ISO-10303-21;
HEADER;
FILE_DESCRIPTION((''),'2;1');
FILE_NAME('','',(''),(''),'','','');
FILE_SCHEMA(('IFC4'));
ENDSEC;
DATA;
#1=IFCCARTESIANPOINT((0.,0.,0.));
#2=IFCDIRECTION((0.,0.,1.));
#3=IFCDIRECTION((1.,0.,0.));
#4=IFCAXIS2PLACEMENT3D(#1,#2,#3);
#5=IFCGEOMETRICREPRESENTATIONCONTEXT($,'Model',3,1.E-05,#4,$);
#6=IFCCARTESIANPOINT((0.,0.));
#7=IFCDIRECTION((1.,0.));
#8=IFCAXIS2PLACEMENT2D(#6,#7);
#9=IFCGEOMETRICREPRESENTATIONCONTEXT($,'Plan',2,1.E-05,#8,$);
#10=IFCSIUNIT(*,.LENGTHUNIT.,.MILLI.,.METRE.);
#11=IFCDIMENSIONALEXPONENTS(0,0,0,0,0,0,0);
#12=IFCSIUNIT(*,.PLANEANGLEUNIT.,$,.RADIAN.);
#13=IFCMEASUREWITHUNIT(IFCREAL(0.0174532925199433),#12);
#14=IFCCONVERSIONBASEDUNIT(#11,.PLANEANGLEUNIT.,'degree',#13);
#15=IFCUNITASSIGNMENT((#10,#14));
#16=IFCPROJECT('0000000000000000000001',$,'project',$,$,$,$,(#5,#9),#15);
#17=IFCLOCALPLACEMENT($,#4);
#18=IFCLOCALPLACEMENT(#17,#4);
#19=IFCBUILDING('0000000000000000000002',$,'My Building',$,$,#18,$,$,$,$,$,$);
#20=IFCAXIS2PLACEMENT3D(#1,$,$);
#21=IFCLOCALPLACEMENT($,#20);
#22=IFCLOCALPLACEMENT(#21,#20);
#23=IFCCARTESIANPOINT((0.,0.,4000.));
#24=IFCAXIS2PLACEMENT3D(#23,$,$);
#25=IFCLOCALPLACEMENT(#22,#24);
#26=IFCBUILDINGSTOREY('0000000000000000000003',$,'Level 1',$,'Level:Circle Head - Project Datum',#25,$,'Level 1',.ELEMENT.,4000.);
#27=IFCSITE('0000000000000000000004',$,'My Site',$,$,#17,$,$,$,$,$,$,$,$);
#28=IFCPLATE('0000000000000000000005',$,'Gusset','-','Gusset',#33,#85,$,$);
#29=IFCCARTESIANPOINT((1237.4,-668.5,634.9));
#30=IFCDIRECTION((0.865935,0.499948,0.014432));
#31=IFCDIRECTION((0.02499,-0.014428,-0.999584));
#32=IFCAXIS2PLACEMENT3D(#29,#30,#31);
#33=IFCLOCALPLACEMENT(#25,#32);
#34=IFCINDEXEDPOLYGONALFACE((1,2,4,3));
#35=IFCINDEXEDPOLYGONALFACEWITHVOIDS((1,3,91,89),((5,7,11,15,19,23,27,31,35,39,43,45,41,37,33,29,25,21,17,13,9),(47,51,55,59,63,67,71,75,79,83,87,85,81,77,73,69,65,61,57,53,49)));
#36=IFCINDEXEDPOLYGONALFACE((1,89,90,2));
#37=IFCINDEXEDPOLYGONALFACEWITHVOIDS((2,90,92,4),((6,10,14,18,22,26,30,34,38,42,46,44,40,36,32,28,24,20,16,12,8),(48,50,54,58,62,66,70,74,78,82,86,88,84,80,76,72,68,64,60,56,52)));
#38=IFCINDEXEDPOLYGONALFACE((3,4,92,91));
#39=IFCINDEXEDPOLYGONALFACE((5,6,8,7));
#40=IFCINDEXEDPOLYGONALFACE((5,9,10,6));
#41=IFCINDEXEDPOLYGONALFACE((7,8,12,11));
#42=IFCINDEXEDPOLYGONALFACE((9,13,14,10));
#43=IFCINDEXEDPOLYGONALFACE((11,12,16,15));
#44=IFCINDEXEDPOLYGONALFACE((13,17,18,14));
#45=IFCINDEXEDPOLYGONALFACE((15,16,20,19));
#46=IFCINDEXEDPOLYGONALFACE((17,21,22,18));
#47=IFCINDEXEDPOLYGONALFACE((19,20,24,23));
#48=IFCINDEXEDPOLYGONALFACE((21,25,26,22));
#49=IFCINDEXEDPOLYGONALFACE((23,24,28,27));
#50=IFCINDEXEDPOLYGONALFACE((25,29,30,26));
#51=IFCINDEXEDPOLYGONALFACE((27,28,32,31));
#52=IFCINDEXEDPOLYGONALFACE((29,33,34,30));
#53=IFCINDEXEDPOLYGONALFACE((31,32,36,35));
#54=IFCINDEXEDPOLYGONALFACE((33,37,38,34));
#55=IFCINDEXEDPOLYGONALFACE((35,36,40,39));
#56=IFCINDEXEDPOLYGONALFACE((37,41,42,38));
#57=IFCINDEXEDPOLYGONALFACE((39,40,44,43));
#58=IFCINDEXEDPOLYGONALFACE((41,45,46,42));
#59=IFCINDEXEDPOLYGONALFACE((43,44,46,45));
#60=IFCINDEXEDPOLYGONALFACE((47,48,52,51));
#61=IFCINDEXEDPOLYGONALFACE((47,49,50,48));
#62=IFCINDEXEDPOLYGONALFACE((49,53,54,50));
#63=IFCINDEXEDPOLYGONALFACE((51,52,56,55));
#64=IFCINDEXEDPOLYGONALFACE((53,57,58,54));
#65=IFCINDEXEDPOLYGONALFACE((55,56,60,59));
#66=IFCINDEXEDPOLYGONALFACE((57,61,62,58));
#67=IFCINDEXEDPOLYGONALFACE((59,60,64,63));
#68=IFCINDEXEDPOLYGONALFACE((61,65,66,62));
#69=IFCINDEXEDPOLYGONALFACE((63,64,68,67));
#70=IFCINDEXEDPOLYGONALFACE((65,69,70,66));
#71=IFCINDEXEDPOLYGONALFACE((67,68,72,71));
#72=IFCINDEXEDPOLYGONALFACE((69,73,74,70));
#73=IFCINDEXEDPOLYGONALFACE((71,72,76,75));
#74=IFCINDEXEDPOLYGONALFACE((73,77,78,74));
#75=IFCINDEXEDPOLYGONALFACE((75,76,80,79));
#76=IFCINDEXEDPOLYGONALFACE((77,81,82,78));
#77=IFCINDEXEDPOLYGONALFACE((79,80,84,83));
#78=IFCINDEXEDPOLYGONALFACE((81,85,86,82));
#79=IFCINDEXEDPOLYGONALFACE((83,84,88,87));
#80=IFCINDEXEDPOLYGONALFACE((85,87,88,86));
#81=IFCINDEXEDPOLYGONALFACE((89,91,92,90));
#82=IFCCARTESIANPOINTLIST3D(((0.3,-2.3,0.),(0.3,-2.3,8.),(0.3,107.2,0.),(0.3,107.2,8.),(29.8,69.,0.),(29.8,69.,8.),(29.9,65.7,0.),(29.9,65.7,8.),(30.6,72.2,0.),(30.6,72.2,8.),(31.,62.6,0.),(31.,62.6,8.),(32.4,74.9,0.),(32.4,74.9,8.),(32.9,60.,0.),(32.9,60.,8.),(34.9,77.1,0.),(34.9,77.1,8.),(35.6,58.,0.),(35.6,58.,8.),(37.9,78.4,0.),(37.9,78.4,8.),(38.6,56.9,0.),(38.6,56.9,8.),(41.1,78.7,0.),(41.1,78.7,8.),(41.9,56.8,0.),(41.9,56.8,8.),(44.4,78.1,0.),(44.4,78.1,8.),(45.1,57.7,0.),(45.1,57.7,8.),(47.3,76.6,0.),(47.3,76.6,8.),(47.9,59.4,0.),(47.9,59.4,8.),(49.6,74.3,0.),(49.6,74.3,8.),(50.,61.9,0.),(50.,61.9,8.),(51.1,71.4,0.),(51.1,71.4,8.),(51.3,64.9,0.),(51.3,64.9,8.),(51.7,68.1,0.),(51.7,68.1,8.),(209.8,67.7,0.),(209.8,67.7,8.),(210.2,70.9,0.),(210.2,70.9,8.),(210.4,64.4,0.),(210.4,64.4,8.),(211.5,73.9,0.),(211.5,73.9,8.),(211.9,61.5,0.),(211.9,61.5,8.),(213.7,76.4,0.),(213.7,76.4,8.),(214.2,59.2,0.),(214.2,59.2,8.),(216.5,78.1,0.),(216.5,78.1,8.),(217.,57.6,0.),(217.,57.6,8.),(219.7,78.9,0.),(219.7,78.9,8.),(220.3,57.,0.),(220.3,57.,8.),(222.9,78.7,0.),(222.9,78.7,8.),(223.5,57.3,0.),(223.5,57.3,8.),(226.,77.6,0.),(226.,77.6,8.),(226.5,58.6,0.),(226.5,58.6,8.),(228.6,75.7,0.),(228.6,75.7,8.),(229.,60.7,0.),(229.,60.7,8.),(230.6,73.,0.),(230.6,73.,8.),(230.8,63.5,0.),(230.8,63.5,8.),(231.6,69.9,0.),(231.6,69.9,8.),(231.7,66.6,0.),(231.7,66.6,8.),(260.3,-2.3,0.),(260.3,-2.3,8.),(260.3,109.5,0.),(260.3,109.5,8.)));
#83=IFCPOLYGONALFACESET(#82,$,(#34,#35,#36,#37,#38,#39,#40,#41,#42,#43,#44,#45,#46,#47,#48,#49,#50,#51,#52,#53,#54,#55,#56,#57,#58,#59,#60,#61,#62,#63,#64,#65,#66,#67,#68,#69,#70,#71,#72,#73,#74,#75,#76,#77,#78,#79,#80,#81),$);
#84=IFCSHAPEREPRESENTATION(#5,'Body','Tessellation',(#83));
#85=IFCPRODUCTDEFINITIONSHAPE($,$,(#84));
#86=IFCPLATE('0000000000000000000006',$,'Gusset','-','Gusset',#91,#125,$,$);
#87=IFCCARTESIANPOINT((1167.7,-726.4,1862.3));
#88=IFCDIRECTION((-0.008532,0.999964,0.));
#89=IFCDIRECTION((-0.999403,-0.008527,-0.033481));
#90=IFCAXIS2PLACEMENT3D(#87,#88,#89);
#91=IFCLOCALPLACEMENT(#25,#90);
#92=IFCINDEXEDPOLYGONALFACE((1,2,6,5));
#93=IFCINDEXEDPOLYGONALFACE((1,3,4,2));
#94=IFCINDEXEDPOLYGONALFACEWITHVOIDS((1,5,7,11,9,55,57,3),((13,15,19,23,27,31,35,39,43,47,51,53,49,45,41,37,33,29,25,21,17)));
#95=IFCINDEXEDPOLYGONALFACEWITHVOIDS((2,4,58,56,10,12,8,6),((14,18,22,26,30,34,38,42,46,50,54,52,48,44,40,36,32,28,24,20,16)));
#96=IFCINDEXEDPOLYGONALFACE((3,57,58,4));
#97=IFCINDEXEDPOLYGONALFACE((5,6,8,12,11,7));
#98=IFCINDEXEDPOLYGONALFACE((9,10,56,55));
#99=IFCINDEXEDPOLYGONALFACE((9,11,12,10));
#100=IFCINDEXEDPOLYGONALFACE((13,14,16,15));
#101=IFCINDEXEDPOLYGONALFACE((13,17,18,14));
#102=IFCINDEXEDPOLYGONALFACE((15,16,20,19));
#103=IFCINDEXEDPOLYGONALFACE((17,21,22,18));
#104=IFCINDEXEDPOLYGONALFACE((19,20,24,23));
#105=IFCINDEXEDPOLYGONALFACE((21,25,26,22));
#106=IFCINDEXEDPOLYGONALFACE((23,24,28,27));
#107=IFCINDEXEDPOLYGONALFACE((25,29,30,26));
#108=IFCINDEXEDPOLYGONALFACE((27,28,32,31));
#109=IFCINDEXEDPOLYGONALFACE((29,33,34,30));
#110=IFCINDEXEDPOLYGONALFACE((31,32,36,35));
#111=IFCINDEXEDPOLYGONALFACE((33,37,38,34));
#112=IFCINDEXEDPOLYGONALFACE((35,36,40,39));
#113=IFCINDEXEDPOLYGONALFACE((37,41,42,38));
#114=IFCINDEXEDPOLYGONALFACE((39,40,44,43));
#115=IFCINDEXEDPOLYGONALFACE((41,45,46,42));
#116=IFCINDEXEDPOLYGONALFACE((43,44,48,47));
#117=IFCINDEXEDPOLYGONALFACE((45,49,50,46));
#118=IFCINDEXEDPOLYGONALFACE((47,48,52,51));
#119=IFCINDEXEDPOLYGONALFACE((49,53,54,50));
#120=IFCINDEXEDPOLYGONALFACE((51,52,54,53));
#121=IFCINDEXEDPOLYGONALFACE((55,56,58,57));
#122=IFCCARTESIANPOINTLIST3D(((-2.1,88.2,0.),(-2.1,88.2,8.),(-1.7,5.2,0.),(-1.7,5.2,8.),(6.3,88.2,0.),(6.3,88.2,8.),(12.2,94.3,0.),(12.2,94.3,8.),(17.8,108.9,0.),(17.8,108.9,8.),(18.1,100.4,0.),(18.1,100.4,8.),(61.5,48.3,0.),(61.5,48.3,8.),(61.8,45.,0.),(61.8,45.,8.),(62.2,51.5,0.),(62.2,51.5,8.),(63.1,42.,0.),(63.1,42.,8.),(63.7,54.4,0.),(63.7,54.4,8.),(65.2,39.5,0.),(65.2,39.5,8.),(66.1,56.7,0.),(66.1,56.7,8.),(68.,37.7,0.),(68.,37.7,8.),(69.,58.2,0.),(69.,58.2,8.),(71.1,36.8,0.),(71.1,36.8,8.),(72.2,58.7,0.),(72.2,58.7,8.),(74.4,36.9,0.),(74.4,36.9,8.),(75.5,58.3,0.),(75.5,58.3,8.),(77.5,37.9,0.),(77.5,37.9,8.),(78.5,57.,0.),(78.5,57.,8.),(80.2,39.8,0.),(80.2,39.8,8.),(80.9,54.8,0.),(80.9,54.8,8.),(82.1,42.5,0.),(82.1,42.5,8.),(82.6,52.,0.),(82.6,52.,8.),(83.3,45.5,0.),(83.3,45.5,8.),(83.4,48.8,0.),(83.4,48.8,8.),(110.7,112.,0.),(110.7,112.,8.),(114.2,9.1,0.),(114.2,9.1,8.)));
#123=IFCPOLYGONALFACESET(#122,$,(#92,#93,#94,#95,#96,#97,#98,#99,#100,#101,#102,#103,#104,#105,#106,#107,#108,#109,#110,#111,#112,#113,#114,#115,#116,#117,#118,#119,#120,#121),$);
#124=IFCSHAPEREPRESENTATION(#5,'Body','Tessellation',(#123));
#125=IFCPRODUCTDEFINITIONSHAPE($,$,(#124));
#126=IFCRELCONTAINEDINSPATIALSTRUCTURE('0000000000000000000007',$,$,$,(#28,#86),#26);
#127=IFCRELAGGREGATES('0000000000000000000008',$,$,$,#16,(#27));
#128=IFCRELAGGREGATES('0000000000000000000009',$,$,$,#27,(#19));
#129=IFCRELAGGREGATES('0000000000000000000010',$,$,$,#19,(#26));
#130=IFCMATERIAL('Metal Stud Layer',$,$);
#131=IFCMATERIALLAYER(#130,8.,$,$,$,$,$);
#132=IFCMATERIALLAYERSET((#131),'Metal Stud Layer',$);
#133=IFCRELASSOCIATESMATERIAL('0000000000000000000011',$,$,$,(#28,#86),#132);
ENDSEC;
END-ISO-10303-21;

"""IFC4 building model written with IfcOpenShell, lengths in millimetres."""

from ifc_helpers import new_model, entity, si_unit, converted_unit, point, frame, frame_2d, origin, origin_with_axes, origin_2d_with_axis, place, context, project, spatial, polyline, circle_curve, line_curve, trimmed, segment, composite_curve, circle, outline, extrude, material, layer, layer_set, element, save


model = new_model("IFC4")

# Units and contexts
model_context = context("Model", 3, precision=1e-05, world=origin_with_axes())
plan_context = context("Plan", 2, precision=1e-05, world=origin_2d_with_axis())
ifc_project = project(units=[si_unit("LENGTHUNIT", "METRE", prefix="MILLI"), converted_unit("PLANEANGLEUNIT", "degree", entity("IfcReal", 0.0174532925199433), si_unit("PLANEANGLEUNIT", "RADIAN"), dimensions=[0, 0, 0, 0, 0, 0, 0])], contexts=[model_context, plan_context])

# Site, building, storey
site_placement = place(None, origin_with_axes())
site = spatial("IfcSite", under=ifc_project, at=site_placement, Name="My Site")
building_placement = place(site_placement, origin_with_axes())
building = spatial("IfcBuilding", under=site, at=building_placement, Name="My Building")
placement_1 = place(None, origin())
placement_2 = place(placement_1, origin())
storey_placement = place(placement_2, frame((0.0, 0.0, 4000.0)))
storey = spatial("IfcBuildingStorey", under=building, at=storey_placement, Name="Level 1", ObjectType="Level:Circle Head - Project Datum", LongName="Level 1", CompositionType="ELEMENT", Elevation=4000.0)

# Plates, openings
ifc_material_1 = material(Name="Metal Stud Layer")
ifc_layer_1 = layer(ifc_material_1, 8.0)
ifc_layer_set_1 = layer_set([ifc_layer_1], Name="Metal Stud Layer")
plate_1_placement = place(storey_placement, frame((1237.4, -668.5, 634.9), z_axis=(0.865935, 0.499948, 0.014432), x_axis=(0.02499, -0.014428, -0.999584)))
plate_1 = element("IfcPlate", 1, at=plate_1_placement, inside=storey, material=ifc_layer_set_1, Name="Gusset", Description="-", ObjectType="Gusset", context=model_context, shape_type="SweptSolid", body=[
    extrude(outline(polyline([(0.3, -2.3), (260.3, -2.3), (260.3, 109.5), (0.3, 107.2), (0.3, -2.3)])), origin_with_axes(), (0.0, 0.0, 1.0), 8.0),
])
opening_1_placement = place(plate_1_placement, frame((220.8, 68.0, 8.5), z_axis=(0.0, 0.0, -1.0), x_axis=(0.476137, 0.879371, 0.0)))
element("IfcOpeningElement", 2, at=opening_1_placement, cuts=plate_1, ObjectType="Opening", context=model_context, shape_type="SweptSolid", body=[
    extrude(circle(Radius=11.0, at=origin_2d_with_axis()), origin(), (0.0, 0.0, 1.0), 9.0),
])
opening_2_placement = place(plate_1_placement, frame((40.7, 67.8, 8.5), z_axis=(0.0, 0.0, -1.0), x_axis=(-0.530273, 0.847827, 0.0)))
element("IfcOpeningElement", 3, at=opening_2_placement, cuts=plate_1, ObjectType="Opening", context=model_context, shape_type="SweptSolid", body=[
    extrude(circle(Radius=11.0, at=origin_2d_with_axis()), origin(), (0.0, 0.0, 1.0), 9.0),
])
plate_2_placement = place(storey_placement, frame((1167.7, -726.4, 1862.3), z_axis=(-0.008532, 0.999964, 0.0), x_axis=(-0.999403, -0.008527, -0.033481)))
plate_2 = element("IfcPlate", 4, at=plate_2_placement, inside=storey, material=ifc_layer_set_1, Name="Gusset", Description="-", ObjectType="Gusset", context=model_context, shape_type="SweptSolid", body=[
    extrude(outline(polyline([(18.1, 100.4), (6.3, 88.2), (-2.1, 88.2), (-1.7, 5.2), (114.2, 9.1), (110.7, 112.0), (17.8, 108.9), (18.1, 100.4)])), origin_with_axes(), (0.0, 0.0, 1.0), 8.0),
])
opening_3_placement = place(plate_2_placement, origin_with_axes())
element("IfcOpeningElement", 5, at=opening_3_placement, cuts=plate_2, ObjectType="Opening", context=model_context, shape_type="SweptSolid", body=[
    extrude(outline(composite_curve([segment(trimmed(line_curve((6.3, 88.2), (-0.99999, -0.004369), 8.455359), [point((6.3, 88.2))], [point((-2.1, 88.2))], True, "CARTESIAN"), True, "CONTINUOUS"), segment(trimmed(circle_curve(frame_2d((-2.2, 108.2), x_axis=(1.0, 0.0)), 20.0), [point((-2.1, 88.2))], [point((12.2, 94.3))], True, "CARTESIAN"), True, "CONTINUOUS"), segment(trimmed(line_curve((12.2, 94.3), (-0.693597, -0.720363), 8.455359), [point((12.2, 94.3))], [point((6.3, 88.2))], True, "CARTESIAN"), True, "CONTINUOUS")], self_intersect=False)), origin(), (0.0, 0.0, 1.0), 8.0),
])
opening_4_placement = place(plate_2_placement, frame((72.5, 47.7, -0.5), z_axis=(0.0, 0.0, 1.0), x_axis=(0.877405, -0.479751, 0.0)))
element("IfcOpeningElement", 6, at=opening_4_placement, cuts=plate_2, ObjectType="Opening", context=model_context, shape_type="SweptSolid", body=[
    extrude(circle(Radius=11.0, at=origin_2d_with_axis()), origin(), (0.0, 0.0, 1.0), 9.0),
])
opening_5_placement = place(plate_2_placement, origin_with_axes())
element("IfcOpeningElement", 7, at=opening_5_placement, cuts=plate_2, ObjectType="Opening", context=model_context, shape_type="SweptSolid", body=[
    extrude(outline(composite_curve([segment(trimmed(line_curve((18.1, 100.4), (-0.693597, -0.720363), 8.455359), [point((18.1, 100.4))], [point((12.2, 94.3))], True, "CARTESIAN"), True, "CONTINUOUS"), segment(trimmed(circle_curve(frame_2d((-2.2, 108.2), x_axis=(1.0, 0.0)), 20.0), [point((12.2, 94.3))], [point((17.8, 108.9))], True, "CARTESIAN"), True, "CONTINUOUS"), segment(trimmed(line_curve((17.8, 108.9), (0.033481, -0.999439), 8.455359), [point((17.8, 108.9))], [point((18.1, 100.4))], True, "CARTESIAN"), True, "CONTINUOUS")], self_intersect=False)), origin(), (0.0, 0.0, 1.0), 8.0),
])

save(model, "model.ifc")
